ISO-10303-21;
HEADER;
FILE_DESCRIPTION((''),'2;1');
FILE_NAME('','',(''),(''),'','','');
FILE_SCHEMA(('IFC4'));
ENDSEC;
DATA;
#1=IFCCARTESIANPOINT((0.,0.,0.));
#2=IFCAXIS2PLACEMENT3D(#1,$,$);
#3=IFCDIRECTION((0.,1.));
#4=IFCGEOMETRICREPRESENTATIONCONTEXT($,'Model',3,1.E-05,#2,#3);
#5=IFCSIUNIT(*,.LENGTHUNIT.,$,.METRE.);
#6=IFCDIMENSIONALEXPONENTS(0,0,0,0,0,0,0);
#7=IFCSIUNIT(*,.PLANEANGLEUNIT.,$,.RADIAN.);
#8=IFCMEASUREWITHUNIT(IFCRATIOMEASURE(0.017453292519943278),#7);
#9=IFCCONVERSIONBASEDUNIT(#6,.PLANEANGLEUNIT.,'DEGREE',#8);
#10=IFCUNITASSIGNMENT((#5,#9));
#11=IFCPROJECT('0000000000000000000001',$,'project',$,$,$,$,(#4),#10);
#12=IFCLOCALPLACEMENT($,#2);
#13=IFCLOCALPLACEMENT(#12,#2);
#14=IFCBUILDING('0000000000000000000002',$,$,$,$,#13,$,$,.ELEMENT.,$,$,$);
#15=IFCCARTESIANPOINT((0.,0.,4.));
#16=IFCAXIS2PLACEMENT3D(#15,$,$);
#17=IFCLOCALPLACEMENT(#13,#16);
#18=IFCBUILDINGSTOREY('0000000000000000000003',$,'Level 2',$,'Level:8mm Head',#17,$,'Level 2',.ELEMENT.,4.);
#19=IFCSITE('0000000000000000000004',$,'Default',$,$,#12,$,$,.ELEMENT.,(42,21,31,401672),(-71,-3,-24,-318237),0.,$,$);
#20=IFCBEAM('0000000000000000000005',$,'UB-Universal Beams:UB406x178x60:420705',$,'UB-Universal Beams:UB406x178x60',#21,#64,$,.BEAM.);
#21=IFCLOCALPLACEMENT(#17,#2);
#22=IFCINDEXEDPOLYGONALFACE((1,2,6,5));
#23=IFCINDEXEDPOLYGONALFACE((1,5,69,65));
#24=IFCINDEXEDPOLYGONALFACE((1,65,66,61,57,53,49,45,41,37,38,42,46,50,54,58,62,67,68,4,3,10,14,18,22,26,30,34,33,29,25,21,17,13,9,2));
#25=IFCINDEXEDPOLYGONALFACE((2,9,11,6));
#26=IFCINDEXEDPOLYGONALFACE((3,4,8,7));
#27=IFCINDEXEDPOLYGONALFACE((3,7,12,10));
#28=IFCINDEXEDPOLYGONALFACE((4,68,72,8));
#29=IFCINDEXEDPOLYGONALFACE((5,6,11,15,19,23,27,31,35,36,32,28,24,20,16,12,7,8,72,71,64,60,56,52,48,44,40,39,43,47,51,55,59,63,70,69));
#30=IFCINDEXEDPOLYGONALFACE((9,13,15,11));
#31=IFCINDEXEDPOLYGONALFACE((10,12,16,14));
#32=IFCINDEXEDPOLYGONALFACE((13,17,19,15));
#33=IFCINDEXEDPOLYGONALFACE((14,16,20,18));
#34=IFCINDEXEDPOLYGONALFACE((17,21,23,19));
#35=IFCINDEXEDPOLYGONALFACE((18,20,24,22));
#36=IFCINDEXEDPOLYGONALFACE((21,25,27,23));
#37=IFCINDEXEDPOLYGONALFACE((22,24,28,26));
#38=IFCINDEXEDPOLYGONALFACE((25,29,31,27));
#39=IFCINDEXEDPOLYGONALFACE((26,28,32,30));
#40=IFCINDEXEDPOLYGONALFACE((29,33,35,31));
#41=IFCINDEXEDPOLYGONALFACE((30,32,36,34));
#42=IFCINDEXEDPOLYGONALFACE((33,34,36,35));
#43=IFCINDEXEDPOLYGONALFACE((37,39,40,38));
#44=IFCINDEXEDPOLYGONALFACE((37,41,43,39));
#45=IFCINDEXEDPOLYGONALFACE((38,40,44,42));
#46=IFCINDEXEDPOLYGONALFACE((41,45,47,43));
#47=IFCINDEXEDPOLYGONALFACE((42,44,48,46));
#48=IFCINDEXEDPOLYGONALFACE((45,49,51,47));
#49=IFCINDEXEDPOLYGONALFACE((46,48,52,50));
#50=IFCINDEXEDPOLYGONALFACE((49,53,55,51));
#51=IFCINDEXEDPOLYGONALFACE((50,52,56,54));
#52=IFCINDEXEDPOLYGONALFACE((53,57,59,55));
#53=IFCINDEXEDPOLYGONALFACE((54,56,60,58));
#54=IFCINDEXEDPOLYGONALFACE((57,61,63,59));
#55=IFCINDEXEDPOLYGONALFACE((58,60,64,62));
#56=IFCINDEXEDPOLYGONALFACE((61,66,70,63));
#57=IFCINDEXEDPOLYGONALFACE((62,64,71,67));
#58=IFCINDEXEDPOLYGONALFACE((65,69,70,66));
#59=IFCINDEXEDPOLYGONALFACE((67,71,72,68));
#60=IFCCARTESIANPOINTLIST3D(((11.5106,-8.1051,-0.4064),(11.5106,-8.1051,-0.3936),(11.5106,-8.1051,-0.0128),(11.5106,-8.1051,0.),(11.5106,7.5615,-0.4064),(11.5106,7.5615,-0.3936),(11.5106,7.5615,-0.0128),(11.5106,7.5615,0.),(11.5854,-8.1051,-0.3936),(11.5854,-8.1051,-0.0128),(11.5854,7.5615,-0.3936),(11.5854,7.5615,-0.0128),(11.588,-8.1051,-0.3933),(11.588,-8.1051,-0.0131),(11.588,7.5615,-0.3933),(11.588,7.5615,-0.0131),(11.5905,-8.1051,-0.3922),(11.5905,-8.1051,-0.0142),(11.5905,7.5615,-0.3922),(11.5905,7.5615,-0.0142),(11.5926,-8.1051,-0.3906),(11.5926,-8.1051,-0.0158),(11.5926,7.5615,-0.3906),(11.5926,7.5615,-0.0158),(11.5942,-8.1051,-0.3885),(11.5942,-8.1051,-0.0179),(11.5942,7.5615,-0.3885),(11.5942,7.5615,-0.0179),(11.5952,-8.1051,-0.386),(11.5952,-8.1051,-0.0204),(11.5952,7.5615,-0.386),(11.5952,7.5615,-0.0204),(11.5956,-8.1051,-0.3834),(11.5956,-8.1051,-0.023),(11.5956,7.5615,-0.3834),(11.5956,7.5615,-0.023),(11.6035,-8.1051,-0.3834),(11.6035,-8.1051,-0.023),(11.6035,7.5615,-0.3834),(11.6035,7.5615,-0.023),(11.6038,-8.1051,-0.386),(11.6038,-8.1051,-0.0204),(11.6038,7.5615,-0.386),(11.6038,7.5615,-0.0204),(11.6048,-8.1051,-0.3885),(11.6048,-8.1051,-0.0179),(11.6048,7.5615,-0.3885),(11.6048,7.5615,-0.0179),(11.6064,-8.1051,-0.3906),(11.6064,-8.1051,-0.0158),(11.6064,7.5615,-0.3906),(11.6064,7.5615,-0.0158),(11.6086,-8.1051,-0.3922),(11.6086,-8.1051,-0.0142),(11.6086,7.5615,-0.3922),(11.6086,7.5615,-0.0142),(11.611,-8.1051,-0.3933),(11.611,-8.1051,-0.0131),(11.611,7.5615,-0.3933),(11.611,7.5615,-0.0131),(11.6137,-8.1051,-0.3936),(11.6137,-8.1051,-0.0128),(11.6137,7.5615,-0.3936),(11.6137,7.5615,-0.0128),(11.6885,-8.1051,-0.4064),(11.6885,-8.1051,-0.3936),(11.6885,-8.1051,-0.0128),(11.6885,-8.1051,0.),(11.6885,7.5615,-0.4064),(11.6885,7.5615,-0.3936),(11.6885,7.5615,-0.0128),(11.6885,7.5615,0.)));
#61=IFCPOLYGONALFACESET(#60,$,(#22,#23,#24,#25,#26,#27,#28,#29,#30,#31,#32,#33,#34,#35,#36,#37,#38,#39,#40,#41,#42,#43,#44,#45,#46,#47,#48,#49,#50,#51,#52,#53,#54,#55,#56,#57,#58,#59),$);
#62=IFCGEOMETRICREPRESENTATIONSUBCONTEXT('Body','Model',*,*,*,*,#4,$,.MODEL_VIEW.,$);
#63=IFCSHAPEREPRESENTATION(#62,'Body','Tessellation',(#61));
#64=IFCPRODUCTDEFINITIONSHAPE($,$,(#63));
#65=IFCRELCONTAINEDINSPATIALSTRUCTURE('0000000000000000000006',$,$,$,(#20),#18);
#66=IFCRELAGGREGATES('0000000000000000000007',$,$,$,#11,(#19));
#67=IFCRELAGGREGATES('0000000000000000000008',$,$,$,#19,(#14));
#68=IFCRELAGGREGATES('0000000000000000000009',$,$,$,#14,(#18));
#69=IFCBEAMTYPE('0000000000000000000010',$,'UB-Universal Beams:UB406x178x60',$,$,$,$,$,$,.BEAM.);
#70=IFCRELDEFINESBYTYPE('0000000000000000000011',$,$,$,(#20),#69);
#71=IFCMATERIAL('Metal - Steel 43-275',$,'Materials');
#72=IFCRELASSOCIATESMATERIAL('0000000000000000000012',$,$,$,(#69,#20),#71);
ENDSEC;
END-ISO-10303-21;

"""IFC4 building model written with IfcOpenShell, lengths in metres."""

from ifc_helpers import new_model, entity, si_unit, converted_unit, direction, frame, origin, place, context, subcontext, project, spatial, line, arc, indexed_curve, outline, extrude, source, transform, mapped, material, type_object, type_shapes, element, save


model = new_model("IFC4")

# Units and contexts
model_context = context("Model", 3, precision=1e-05, world=origin(), true_north=direction((0.0, 1.0)))
body_context = subcontext(model_context, "Body", "Model", "MODEL_VIEW")
ifc_project = project(units=[si_unit("LENGTHUNIT", "METRE"), converted_unit("PLANEANGLEUNIT", "DEGREE", entity("IfcRatioMeasure", 0.017453292519943278), si_unit("PLANEANGLEUNIT", "RADIAN"), dimensions=[0, 0, 0, 0, 0, 0, 0])], contexts=[model_context])

# Site, building, storey
site_placement = place(None, origin())
site = spatial("IfcSite", under=ifc_project, at=site_placement, Name="Default", CompositionType="ELEMENT", RefLatitude=(42, 21, 31, 401672), RefLongitude=(-71, -3, -24, -318237), RefElevation=0.0)
building_placement = place(site_placement, origin())
building = spatial("IfcBuilding", under=site, at=building_placement, CompositionType="ELEMENT")
storey_placement = place(building_placement, frame((0.0, 0.0, 4.0)))
storey = spatial("IfcBuildingStorey", under=building, at=storey_placement, Name="Level 2", ObjectType="Level:8mm Head", LongName="Level 2", CompositionType="ELEMENT", Elevation=4.0)

# Shared definitions
ifc_material_1 = material(Name="Metal - Steel 43-275", Category="Materials")

# Beam
beam_type_1 = type_object("IfcBeamType", Name="UB-Universal Beams:UB406x178x60", PredefinedType="BEAM", material=ifc_material_1)
shared_shape_1 = source(origin(), body_context, "Body", "SweptSolid", [
    extrude(outline(indexed_curve([(-0.089, -0.2032), (0.0889, -0.2032), (0.0889, -0.1904), (0.0141, -0.1904), (0.0069, -0.1874), (0.0039, -0.1802), (0.0039, 0.1802), (0.0069, 0.1874), (0.0141, 0.1904), (0.0889, 0.1904), (0.0889, 0.2032), (-0.089, 0.2032), (-0.089, 0.1904), (-0.0142, 0.1904), (-0.0069, 0.1874), (-0.004, 0.1802), (-0.004, -0.1802), (-0.0069, -0.1874), (-0.0142, -0.1904), (-0.089, -0.1904)], segments=[line(1, 2, 3, 4), arc(4, 5, 6), line(6, 7), arc(7, 8, 9), line(9, 10, 11, 12, 13, 14), arc(14, 15, 16), line(16, 17), arc(17, 18, 19), line(19, 20, 1)], self_intersect=False)), frame((11.5995, -8.1051, 3.7968), z_axis=(0.0, 1.0, 0.0), x_axis=(-1.0, 0.0, 0.0)), (0.0, 0.0, 1.0), 15.6666),
])
type_shapes(beam_type_1, [shared_shape_1])
beam_1_placement = place(storey_placement, frame((0.0, 0.0, -4.0)))
element("IfcBeam", 1, at=beam_1_placement, inside=storey, type_object=beam_type_1, material=ifc_material_1, Name="UB-Universal Beams:UB406x178x60:420705", ObjectType="UB-Universal Beams:UB406x178x60", PredefinedType="BEAM", context=body_context, shape_type="MappedRepresentation", body=[
    mapped(shared_shape_1, transform((0.0, 0.0, 0.0), scale=1.0)),
])

save(model, "model.ifc")
